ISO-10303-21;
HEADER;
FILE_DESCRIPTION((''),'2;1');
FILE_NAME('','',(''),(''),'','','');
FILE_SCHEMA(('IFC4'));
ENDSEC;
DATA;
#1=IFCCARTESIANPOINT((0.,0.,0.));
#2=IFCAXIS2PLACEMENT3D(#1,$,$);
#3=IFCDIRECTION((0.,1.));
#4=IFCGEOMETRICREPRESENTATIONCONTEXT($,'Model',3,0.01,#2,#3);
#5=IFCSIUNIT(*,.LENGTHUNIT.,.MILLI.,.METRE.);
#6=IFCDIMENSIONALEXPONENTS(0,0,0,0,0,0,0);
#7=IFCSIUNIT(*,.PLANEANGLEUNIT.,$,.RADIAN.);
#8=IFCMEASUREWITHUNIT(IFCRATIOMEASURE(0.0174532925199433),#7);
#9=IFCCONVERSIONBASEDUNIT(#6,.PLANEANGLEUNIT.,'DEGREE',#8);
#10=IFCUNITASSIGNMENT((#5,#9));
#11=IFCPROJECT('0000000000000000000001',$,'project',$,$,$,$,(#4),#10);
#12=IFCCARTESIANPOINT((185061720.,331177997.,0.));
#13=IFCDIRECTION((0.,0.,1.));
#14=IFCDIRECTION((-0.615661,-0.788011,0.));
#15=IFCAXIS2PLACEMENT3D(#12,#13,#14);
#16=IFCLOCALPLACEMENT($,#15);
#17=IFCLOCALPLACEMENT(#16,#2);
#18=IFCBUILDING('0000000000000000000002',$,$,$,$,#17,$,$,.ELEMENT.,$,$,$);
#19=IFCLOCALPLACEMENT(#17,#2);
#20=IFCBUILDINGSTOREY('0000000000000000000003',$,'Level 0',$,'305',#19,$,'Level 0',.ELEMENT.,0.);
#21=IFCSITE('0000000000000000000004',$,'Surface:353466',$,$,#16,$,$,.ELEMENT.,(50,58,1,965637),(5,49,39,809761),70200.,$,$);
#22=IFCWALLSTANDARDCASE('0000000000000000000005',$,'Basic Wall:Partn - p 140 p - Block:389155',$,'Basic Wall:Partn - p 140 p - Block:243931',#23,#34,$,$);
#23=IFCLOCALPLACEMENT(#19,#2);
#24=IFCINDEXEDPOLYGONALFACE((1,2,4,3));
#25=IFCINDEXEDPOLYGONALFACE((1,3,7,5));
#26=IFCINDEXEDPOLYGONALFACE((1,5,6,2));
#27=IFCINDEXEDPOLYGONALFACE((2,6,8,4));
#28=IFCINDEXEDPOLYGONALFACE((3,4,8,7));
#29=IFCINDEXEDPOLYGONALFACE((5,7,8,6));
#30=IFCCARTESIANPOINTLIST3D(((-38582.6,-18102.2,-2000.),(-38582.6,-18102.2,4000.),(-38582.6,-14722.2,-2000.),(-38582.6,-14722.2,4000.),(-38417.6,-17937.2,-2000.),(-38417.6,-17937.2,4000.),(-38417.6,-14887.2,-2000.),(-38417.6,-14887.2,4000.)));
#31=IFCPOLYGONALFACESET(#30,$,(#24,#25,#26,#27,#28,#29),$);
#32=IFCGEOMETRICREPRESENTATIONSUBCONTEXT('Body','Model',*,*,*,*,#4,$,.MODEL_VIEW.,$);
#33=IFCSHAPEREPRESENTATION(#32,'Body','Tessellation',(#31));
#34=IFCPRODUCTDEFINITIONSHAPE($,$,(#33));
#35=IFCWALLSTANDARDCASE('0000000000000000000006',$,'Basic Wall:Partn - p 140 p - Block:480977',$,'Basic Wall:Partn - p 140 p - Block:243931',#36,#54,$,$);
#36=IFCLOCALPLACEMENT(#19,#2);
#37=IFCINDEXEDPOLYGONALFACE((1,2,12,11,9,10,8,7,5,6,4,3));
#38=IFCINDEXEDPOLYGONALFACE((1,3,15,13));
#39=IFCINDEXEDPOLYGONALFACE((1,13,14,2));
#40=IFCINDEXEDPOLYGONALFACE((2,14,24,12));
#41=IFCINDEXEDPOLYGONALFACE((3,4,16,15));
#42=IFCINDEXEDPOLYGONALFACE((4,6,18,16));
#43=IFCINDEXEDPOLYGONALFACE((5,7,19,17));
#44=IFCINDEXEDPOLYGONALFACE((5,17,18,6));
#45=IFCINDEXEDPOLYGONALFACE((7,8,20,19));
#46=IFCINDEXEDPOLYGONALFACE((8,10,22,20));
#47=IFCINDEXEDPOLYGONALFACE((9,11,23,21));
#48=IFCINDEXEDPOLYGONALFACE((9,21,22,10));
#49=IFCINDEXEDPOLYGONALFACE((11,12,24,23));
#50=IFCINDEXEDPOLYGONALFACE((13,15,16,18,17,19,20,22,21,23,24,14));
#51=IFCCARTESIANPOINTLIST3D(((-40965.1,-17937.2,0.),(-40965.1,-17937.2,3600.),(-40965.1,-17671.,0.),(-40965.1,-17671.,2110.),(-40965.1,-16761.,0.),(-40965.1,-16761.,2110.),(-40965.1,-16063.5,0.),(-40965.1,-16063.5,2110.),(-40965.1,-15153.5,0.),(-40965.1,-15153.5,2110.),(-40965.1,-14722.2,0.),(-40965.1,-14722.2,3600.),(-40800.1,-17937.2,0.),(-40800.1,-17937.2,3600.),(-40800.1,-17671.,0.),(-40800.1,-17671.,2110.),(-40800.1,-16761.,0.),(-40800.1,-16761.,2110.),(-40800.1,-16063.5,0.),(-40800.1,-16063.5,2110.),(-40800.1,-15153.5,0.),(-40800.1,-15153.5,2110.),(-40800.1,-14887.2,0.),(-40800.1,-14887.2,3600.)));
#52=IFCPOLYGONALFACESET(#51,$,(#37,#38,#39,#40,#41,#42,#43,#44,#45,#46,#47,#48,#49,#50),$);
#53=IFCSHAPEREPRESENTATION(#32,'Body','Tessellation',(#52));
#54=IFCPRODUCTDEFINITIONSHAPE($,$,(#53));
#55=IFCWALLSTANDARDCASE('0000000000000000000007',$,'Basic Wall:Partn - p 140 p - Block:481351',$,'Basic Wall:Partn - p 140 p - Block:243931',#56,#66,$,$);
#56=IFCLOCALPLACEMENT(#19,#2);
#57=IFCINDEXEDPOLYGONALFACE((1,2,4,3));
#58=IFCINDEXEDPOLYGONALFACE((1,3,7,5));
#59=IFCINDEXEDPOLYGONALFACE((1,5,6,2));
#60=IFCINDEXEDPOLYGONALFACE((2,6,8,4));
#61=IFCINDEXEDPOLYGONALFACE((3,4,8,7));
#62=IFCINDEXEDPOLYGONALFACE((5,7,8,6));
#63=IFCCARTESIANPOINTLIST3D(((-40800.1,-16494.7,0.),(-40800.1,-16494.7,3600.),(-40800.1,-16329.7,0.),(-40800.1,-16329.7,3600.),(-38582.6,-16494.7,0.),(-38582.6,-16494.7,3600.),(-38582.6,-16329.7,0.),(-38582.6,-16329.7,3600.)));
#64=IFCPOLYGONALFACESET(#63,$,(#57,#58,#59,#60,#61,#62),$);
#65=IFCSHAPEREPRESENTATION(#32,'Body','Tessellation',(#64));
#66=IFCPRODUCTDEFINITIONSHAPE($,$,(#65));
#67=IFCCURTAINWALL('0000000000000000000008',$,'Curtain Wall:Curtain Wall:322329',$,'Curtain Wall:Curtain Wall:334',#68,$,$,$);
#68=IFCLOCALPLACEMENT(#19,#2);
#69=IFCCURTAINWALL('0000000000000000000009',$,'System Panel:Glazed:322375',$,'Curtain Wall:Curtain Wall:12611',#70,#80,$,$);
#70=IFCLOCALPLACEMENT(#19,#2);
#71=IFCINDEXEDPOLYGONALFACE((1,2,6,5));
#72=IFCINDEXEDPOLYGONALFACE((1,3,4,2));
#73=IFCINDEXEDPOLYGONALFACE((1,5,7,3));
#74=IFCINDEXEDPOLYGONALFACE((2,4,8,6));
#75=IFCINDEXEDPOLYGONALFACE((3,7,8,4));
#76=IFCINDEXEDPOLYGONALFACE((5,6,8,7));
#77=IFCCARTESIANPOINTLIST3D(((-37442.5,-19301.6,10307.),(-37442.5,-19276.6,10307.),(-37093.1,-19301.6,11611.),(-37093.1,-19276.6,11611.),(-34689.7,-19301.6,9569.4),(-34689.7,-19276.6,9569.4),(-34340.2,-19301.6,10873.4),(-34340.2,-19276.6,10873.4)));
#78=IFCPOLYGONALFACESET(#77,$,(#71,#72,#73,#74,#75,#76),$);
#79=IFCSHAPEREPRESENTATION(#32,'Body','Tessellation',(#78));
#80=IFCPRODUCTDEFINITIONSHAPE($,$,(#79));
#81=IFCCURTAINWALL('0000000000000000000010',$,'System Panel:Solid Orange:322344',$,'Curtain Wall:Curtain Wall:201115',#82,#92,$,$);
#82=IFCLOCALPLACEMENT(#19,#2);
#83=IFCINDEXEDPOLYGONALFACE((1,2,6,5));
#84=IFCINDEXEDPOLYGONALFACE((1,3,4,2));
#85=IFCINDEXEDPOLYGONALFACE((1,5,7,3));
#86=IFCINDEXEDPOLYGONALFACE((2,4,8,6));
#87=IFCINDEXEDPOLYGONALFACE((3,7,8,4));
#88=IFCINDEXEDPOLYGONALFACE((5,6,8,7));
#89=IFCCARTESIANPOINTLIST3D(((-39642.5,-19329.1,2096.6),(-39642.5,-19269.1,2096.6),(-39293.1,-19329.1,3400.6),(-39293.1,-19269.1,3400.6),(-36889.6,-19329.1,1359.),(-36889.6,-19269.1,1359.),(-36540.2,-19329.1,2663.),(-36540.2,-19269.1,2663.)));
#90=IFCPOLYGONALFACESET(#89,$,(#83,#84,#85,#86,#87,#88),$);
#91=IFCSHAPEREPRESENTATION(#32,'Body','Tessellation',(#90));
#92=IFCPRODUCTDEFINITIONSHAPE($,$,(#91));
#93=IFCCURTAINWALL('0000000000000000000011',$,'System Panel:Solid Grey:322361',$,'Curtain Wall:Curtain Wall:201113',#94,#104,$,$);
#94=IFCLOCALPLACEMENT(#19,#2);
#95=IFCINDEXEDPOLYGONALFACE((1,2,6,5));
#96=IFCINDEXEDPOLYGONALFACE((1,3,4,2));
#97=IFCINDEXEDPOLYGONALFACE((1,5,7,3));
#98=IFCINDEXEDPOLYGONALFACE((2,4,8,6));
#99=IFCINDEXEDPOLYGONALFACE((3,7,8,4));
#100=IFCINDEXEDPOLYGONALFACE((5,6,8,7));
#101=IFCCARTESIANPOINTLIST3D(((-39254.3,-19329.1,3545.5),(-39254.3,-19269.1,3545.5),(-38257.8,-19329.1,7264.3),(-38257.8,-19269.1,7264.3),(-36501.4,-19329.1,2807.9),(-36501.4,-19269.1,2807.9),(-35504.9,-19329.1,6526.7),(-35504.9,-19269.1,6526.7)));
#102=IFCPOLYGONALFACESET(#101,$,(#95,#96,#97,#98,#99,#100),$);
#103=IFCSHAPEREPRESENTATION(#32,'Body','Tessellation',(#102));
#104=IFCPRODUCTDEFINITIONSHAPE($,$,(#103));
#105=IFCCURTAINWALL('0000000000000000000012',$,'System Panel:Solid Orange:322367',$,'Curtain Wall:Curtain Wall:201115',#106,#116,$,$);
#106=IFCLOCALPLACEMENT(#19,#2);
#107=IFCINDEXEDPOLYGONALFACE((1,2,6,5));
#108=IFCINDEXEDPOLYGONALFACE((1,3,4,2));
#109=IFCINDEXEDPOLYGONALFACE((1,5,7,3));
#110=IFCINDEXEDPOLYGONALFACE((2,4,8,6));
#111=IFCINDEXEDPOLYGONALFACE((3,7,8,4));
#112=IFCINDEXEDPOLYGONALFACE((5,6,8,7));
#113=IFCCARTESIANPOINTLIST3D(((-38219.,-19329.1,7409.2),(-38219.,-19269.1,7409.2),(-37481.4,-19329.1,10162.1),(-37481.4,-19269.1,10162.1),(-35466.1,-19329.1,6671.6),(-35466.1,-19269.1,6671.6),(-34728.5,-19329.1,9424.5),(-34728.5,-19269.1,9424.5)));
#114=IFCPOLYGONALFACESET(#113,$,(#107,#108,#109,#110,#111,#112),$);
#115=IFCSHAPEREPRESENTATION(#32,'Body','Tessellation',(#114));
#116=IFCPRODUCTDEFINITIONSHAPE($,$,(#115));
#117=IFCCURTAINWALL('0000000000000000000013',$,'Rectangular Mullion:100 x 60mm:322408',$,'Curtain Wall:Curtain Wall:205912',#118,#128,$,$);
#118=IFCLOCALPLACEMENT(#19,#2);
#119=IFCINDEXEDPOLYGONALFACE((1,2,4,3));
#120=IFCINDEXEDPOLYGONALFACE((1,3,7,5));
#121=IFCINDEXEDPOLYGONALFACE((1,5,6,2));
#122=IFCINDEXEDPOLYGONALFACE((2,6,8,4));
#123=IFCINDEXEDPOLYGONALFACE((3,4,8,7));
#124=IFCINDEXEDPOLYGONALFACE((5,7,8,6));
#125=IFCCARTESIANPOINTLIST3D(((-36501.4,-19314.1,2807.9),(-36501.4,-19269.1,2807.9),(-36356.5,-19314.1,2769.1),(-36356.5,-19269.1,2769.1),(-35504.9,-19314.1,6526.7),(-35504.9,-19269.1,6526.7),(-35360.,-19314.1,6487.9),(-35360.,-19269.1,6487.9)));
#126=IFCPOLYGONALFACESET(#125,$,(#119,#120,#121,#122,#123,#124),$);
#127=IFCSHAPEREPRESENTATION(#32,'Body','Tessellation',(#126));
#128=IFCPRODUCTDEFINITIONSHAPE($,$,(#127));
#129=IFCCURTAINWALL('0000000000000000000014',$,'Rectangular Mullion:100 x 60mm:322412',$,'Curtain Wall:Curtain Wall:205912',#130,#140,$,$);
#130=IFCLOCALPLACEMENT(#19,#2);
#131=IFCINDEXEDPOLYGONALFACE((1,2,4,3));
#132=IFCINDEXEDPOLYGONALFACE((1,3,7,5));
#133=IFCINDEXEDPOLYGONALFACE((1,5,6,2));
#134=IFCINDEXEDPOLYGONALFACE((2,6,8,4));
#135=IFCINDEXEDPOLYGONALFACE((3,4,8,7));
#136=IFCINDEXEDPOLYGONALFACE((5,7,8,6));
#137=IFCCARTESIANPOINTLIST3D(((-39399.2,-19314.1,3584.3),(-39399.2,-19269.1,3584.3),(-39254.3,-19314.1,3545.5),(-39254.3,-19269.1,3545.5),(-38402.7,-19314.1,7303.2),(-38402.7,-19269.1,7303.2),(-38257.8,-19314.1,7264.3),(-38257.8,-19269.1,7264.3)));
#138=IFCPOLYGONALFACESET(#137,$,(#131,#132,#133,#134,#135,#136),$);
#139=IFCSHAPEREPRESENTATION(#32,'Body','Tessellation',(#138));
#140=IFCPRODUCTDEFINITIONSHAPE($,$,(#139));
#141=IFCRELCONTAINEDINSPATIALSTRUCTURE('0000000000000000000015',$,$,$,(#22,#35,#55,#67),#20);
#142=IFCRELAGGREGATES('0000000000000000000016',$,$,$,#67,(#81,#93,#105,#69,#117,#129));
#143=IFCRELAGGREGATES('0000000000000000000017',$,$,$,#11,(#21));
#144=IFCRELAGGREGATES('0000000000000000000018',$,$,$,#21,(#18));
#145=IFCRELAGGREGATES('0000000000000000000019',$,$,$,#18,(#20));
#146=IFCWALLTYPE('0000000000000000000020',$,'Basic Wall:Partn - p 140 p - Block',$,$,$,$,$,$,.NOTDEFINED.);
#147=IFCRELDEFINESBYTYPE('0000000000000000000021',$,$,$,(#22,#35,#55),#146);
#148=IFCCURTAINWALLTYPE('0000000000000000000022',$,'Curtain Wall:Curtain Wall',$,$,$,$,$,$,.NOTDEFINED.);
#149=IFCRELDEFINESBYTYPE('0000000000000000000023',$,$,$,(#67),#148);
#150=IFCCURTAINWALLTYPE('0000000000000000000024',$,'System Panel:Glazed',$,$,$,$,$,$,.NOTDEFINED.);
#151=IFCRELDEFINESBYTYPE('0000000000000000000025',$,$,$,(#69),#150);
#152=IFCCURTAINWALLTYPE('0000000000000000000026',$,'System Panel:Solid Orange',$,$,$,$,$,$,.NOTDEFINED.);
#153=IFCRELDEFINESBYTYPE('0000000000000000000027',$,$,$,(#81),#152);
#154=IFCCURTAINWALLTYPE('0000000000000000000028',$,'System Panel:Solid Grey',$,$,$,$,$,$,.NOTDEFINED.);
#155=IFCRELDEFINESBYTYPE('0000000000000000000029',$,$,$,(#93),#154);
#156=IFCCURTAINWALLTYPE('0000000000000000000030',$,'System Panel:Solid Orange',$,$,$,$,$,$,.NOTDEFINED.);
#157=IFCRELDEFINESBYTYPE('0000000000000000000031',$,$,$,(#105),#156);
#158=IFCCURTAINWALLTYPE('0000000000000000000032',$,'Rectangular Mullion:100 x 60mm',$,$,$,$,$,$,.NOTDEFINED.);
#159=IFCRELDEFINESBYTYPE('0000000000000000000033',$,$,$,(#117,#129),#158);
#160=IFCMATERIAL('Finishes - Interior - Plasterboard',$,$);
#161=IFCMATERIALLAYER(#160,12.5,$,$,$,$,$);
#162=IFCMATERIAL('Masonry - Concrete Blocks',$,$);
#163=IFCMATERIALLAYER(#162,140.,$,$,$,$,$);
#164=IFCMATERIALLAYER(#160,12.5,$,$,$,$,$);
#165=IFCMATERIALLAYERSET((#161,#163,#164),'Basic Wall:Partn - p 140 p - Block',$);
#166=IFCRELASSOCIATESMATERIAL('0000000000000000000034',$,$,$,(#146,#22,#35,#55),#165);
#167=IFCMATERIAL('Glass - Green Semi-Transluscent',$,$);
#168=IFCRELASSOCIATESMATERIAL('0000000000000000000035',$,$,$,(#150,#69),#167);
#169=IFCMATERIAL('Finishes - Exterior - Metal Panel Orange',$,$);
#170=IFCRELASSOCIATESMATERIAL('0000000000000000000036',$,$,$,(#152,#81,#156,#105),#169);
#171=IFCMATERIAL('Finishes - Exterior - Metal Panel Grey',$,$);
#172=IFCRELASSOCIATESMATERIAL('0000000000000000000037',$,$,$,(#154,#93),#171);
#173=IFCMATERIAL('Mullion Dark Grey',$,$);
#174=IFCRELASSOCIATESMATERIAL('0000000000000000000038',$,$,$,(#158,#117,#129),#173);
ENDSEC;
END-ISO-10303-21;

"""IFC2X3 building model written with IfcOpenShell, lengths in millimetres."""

from ifc_helpers import new_model, entity, si_unit, converted_unit, direction, frame, frame_2d, origin, place, context, subcontext, project, spatial, polyline, rectangle, outline, extrude, clip, halfspace, bounded_halfspace, source, transform, mapped, material, layer, layer_set, layer_usage, type_object, type_shapes, element, aggregate, save


model = new_model("IFC2X3")

# Units and contexts
model_context = context("Model", 3, precision=0.01, world=origin(), true_north=direction((0.0, 1.0)))
body_context = subcontext(model_context, "Body", "Model", "MODEL_VIEW")
ifc_project = project(units=[si_unit("LENGTHUNIT", "METRE", prefix="MILLI"), converted_unit("PLANEANGLEUNIT", "DEGREE", entity("IfcRatioMeasure", 0.0174532925199433), si_unit("PLANEANGLEUNIT", "RADIAN"), dimensions=[0, 0, 0, 0, 0, 0, 0])], contexts=[model_context])

# Site, building, storey
site_placement = place(None, frame((185061720.0, 331177997.0, 0.0), z_axis=(0.0, 0.0, 1.0), x_axis=(-0.615661, -0.788011, 0.0)))
site = spatial("IfcSite", under=ifc_project, at=site_placement, Name="Surface:353466", CompositionType="ELEMENT", RefLatitude=(50, 58, 1, 965637), RefLongitude=(5, 49, 39, 809761), RefElevation=70200.0)
building_placement = place(site_placement, origin())
building = spatial("IfcBuilding", under=site, at=building_placement, CompositionType="ELEMENT")
storey_placement = place(building_placement, origin())
storey = spatial("IfcBuildingStorey", under=building, at=storey_placement, Name="Level 0", ObjectType="305", LongName="Level 0", CompositionType="ELEMENT", Elevation=0.0)

# Wall
ifc_material_1 = material(Name="Finishes - Interior - Plasterboard")
ifc_layer_1 = layer(ifc_material_1, 12.5)
ifc_material_2 = material(Name="Masonry - Concrete Blocks")
ifc_layer_2 = layer(ifc_material_2, 140.0)
ifc_layer_3 = layer(ifc_material_1, 12.5)
ifc_layer_set_1 = layer_set([ifc_layer_1, ifc_layer_2, ifc_layer_3], Name="Basic Wall:Partn - p 140 p - Block")
ifc_layer_usage_1 = layer_usage(ifc_layer_set_1, "AXIS2", "NEGATIVE", 82.5)
wall_type = type_object("IfcWallType", Name="Basic Wall:Partn - p 140 p - Block", PredefinedType="NOTDEFINED", material=ifc_layer_set_1)
wall_1_placement = place(storey_placement, frame((-38500.1, -18102.2, -2000.0), z_axis=(0.0, 0.0, 1.0), x_axis=(0.0, 1.0, 0.0)))
element("IfcWallStandardCase", 1, at=wall_1_placement, inside=storey, type_object=wall_type, material=ifc_layer_usage_1, Name="Basic Wall:Partn - p 140 p - Block:389155", ObjectType="Basic Wall:Partn - p 140 p - Block:243931", context=body_context, shape_type="Clipping", body=[
    clip(extrude(outline(polyline([(3215.0, -82.5), (3380.0, 82.5), (0.0, 82.5), (165.0, -82.5), (3215.0, -82.5)])), origin(), (0.0, 0.0, 1.0), 6000.0), halfspace(frame((0.0, 0.0, -2000.0)), True)),
])

# Wall, openings
ifc_layer_usage_2 = layer_usage(ifc_layer_set_1, "AXIS2", "NEGATIVE", 82.5)
wall_2_placement = place(storey_placement, frame((-40882.6, -14722.2, 0.0), z_axis=(0.0, 0.0, 1.0), x_axis=(0.0, -1.0, 0.0)))
wall_2 = element("IfcWallStandardCase", 2, at=wall_2_placement, inside=storey, type_object=wall_type, material=ifc_layer_usage_2, Name="Basic Wall:Partn - p 140 p - Block:480977", ObjectType="Basic Wall:Partn - p 140 p - Block:243931", context=body_context, shape_type="Clipping", body=[
    clip(extrude(outline(polyline([(3215.0, 82.5), (1772.5, 82.5), (1607.5, 82.5), (165.0, 82.5), (0.0, -82.5), (3215.0, -82.5), (3215.0, 82.5)])), origin(), (0.0, 0.0, 1.0), 3600.0), bounded_halfspace(frame((3215.0, 82.5, 3600.0), z_axis=(0.0, 0.0, -1.0), x_axis=(0.0, 1.0, 0.0)), True, frame((3215.0, 82.5, 3600.0)), polyline([(0.0, 0.0), (-1442.5, 0.0), (-1607.5, 0.0), (-3050.0, 0.0), (-3215.0, -165.0), (0.0, -165.0), (0.0, 0.0)]))),
])
opening_1_placement = place(wall_2_placement, frame((1341.2, -1606.5, 0.0)))
element("IfcOpeningElement", 3, at=opening_1_placement, cuts=wall_2, ObjectType="Opening", context=body_context, shape_type="SweptSolid", body=[
    extrude(rectangle(XDim=2110.0, YDim=910.0, at=frame_2d((0.0, 0.0), x_axis=(0.0, 1.0))), frame((-455.0, 0.0, 1055.0), z_axis=(0.0, 1.0, 0.0), x_axis=(-1.0, 0.0, 0.0)), (0.0, 0.0, 1.0), 3048.0),
])
opening_2_placement = place(wall_2_placement, frame((2948.8, -1606.5, 0.0)))
element("IfcOpeningElement", 4, at=opening_2_placement, cuts=wall_2, ObjectType="Opening", context=body_context, shape_type="SweptSolid", body=[
    extrude(rectangle(XDim=2110.0, YDim=910.0, at=frame_2d((0.0, 0.0), x_axis=(1.0, 0.0))), frame((-455.0, 0.0, 1055.0), z_axis=(0.0, 1.0, 0.0), x_axis=(0.0, 0.0, 1.0)), (0.0, 0.0, 1.0), 3048.0),
])
opening_3_placement = place(wall_2_placement, frame((431.2, -82.5, 0.0)))
element("IfcOpeningElement", 5, at=opening_3_placement, cuts=wall_2, ObjectType="Opening", context=body_context, shape_type="SweptSolid", body=[
    extrude(rectangle(XDim=2110.0, YDim=910.0, at=frame_2d((1055.0, 455.0), x_axis=(1.0, 0.0))), frame((0.0, 0.0, 0.0), z_axis=(0.0, 1.0, 0.0), x_axis=(0.0, 0.0, 1.0)), (0.0, 0.0, 1.0), 165.0),
])
opening_4_placement = place(wall_2_placement, frame((2038.8, -82.5, 0.0)))
element("IfcOpeningElement", 6, at=opening_4_placement, cuts=wall_2, ObjectType="Opening", context=body_context, shape_type="SweptSolid", body=[
    extrude(rectangle(XDim=2110.0, YDim=910.0, at=frame_2d((1055.0, 455.0), x_axis=(1.0, 0.0))), frame((0.0, 0.0, 0.0), z_axis=(0.0, 1.0, 0.0), x_axis=(0.0, 0.0, 1.0)), (0.0, 0.0, 1.0), 165.0),
])

# Wall
ifc_layer_usage_3 = layer_usage(ifc_layer_set_1, "AXIS2", "NEGATIVE", 82.5)
wall_3_placement = place(storey_placement, frame((-38582.6, -16412.2, 0.0), z_axis=(0.0, 0.0, 1.0), x_axis=(-1.0, 0.0, 0.0)))
element("IfcWallStandardCase", 7, at=wall_3_placement, inside=storey, type_object=wall_type, material=ifc_layer_usage_3, Name="Basic Wall:Partn - p 140 p - Block:481351", ObjectType="Basic Wall:Partn - p 140 p - Block:243931", context=body_context, shape_type="Clipping", body=[
    clip(extrude(rectangle(XDim=2217.5, YDim=165.0, at=frame_2d((1108.8, 0.0), x_axis=(-1.0, 0.0))), origin(), (0.0, 0.0, 1.0), 3600.0), bounded_halfspace(frame((0.0, -82.5, 3600.0), z_axis=(0.0, 0.0, -1.0), x_axis=(-1.0, 0.0, 0.0)), True, frame((0.0, -82.5, 3600.0)), polyline([(0.0, 0.0), (2217.5, 0.0), (2217.5, 165.0), (0.0, 165.0), (0.0, 0.0)]))),
])

# Curtain walls
curtain_wall_type_1 = type_object("IfcCurtainWallType", Name="Curtain Wall:Curtain Wall", PredefinedType="NOTDEFINED")
curtain_wall_1_placement = place(storey_placement, origin())
curtain_wall_1 = element("IfcCurtainWall", 8, at=curtain_wall_1_placement, inside=storey, type_object=curtain_wall_type_1, Name="Curtain Wall:Curtain Wall:322329", ObjectType="Curtain Wall:Curtain Wall:334")
ifc_material_3 = material(Name="Finishes - Exterior - Metal Panel Grey")
ifc_material_4 = material(Name="Glass - Green Semi-Transluscent")
curtain_wall_type_2 = type_object("IfcCurtainWallType", Name="System Panel:Glazed", PredefinedType="NOTDEFINED", material=ifc_material_4)
shared_shape_1 = source(origin(), body_context, "Body", "SweptSolid", [
    extrude(rectangle(XDim=25.0, YDim=2850.0, at=frame_2d((0.0, 0.0), x_axis=(1.0, 0.0))), frame((0.0, -10.0, 0.0), z_axis=(0.0, 0.0, 1.0), x_axis=(0.0, 1.0, 0.0)), (0.0, 0.0, 1.0), 1350.0),
])
type_shapes(curtain_wall_type_2, [shared_shape_1])
curtain_wall_2_placement = place(storey_placement, frame((-36066.1, -19299.1, 9938.2), z_axis=(0.258819, 0.0, 0.965926), x_axis=(-0.965926, 0.0, 0.258819)))
curtain_wall_2 = element("IfcCurtainWall", 9, at=curtain_wall_2_placement, type_object=curtain_wall_type_2, material=ifc_material_4, Name="System Panel:Glazed:322375", ObjectType="Curtain Wall:Curtain Wall:12611", context=body_context, shape_type="MappedRepresentation", body=[
    mapped(shared_shape_1, transform((0.0, 0.0, 0.0), scale=1.0)),
])
ifc_material_5 = material(Name="Finishes - Exterior - Metal Panel Orange")
curtain_wall_type_3 = type_object("IfcCurtainWallType", Name="System Panel:Solid Orange", PredefinedType="NOTDEFINED", material=ifc_material_5)
shared_shape_2 = source(origin(), body_context, "Body", "SweptSolid", [
    extrude(rectangle(XDim=60.0, YDim=2850.0, at=frame_2d((0.0, 0.0), x_axis=(1.0, 0.0))), frame((0.0, 0.0, 0.0), z_axis=(0.0, 0.0, 1.0), x_axis=(0.0, 1.0, 0.0)), (0.0, 0.0, 1.0), 1350.0),
])
type_shapes(curtain_wall_type_3, [shared_shape_2])
curtain_wall_3_placement = place(storey_placement, frame((-38266.1, -19299.1, 1727.8), z_axis=(0.258819, 0.0, 0.965926), x_axis=(-0.965926, 0.0, 0.258819)))
curtain_wall_3 = element("IfcCurtainWall", 10, at=curtain_wall_3_placement, type_object=curtain_wall_type_3, material=ifc_material_5, Name="System Panel:Solid Orange:322344", ObjectType="Curtain Wall:Curtain Wall:201115", context=body_context, shape_type="MappedRepresentation", body=[
    mapped(shared_shape_2, transform((0.0, 0.0, 0.0), scale=1.0)),
])
curtain_wall_type_4 = type_object("IfcCurtainWallType", Name="System Panel:Solid Grey", PredefinedType="NOTDEFINED", material=ifc_material_3)
shared_shape_3 = source(origin(), body_context, "Body", "SweptSolid", [
    extrude(rectangle(XDim=60.0, YDim=2850.0, at=frame_2d((0.0, 0.0), x_axis=(1.0, 0.0))), frame((0.0, 0.0, 0.0), z_axis=(0.0, 0.0, 1.0), x_axis=(0.0, 1.0, 0.0)), (0.0, 0.0, 1.0), 3850.0),
])
type_shapes(curtain_wall_type_4, [shared_shape_3])
curtain_wall_4_placement = place(storey_placement, frame((-37877.8, -19299.1, 3176.7), z_axis=(0.258819, 0.0, 0.965926), x_axis=(-0.965926, 0.0, 0.258819)))
curtain_wall_4 = element("IfcCurtainWall", 11, at=curtain_wall_4_placement, type_object=curtain_wall_type_4, material=ifc_material_3, Name="System Panel:Solid Grey:322361", ObjectType="Curtain Wall:Curtain Wall:201113", context=body_context, shape_type="MappedRepresentation", body=[
    mapped(shared_shape_3, transform((0.0, 0.0, 0.0), scale=1.0)),
])
curtain_wall_type_5 = type_object("IfcCurtainWallType", Name="System Panel:Solid Orange", PredefinedType="NOTDEFINED", material=ifc_material_5)
shared_shape_4 = source(origin(), body_context, "Body", "SweptSolid", [
    extrude(rectangle(XDim=60.0, YDim=2850.0, at=frame_2d((0.0, 0.0), x_axis=(1.0, 0.0))), frame((0.0, 0.0, 0.0), z_axis=(0.0, 0.0, 1.0), x_axis=(0.0, 1.0, 0.0)), (0.0, 0.0, 1.0), 2850.0),
])
type_shapes(curtain_wall_type_5, [shared_shape_4])
curtain_wall_5_placement = place(storey_placement, frame((-36842.6, -19299.1, 7040.4), z_axis=(0.258819, 0.0, 0.965926), x_axis=(-0.965926, 0.0, 0.258819)))
curtain_wall_5 = element("IfcCurtainWall", 12, at=curtain_wall_5_placement, type_object=curtain_wall_type_5, material=ifc_material_5, Name="System Panel:Solid Orange:322367", ObjectType="Curtain Wall:Curtain Wall:201115", context=body_context, shape_type="MappedRepresentation", body=[
    mapped(shared_shape_4, transform((0.0, 0.0, 0.0), scale=1.0)),
])
ifc_material_6 = material(Name="Mullion Dark Grey")
curtain_wall_type_6 = type_object("IfcCurtainWallType", Name="Rectangular Mullion:100 x 60mm", PredefinedType="NOTDEFINED", material=ifc_material_6)
shared_shape_5 = source(origin(), body_context, "Body", "SweptSolid", [
    extrude(rectangle(XDim=45.0, YDim=150.0, at=frame_2d((0.0, 0.0), x_axis=(1.0, 0.0))), frame((0.0, 7.5, -3850.0), z_axis=(0.0, 0.0, 1.0), x_axis=(0.0, -1.0, 0.0)), (0.0, 0.0, 1.0), 3850.0),
])
type_shapes(curtain_wall_type_6, [shared_shape_5])
curtain_wall_6_placement = place(storey_placement, frame((-36428.9, -19299.1, 2788.5), z_axis=(-0.258819, 0.0, -0.965926), x_axis=(-0.965926, 0.0, 0.258819)))
curtain_wall_6 = element("IfcCurtainWall", 13, at=curtain_wall_6_placement, type_object=curtain_wall_type_6, material=ifc_material_6, Name="Rectangular Mullion:100 x 60mm:322408", ObjectType="Curtain Wall:Curtain Wall:205912", context=body_context, shape_type="MappedRepresentation", body=[
    mapped(shared_shape_5, transform((0.0, 0.0, 0.0), scale=1.0)),
])
curtain_wall_7_placement = place(storey_placement, frame((-39326.7, -19299.1, 3564.9), z_axis=(-0.258819, 0.0, -0.965926), x_axis=(-0.965926, 0.0, 0.258819)))
curtain_wall_7 = element("IfcCurtainWall", 14, at=curtain_wall_7_placement, type_object=curtain_wall_type_6, material=ifc_material_6, Name="Rectangular Mullion:100 x 60mm:322412", ObjectType="Curtain Wall:Curtain Wall:205912", context=body_context, shape_type="MappedRepresentation", body=[
    mapped(shared_shape_5, transform((0.0, 0.0, 0.0), scale=1.0)),
])
aggregate(curtain_wall_1, [curtain_wall_3, curtain_wall_4, curtain_wall_5, curtain_wall_2, curtain_wall_6, curtain_wall_7])

save(model, "model.ifc")
